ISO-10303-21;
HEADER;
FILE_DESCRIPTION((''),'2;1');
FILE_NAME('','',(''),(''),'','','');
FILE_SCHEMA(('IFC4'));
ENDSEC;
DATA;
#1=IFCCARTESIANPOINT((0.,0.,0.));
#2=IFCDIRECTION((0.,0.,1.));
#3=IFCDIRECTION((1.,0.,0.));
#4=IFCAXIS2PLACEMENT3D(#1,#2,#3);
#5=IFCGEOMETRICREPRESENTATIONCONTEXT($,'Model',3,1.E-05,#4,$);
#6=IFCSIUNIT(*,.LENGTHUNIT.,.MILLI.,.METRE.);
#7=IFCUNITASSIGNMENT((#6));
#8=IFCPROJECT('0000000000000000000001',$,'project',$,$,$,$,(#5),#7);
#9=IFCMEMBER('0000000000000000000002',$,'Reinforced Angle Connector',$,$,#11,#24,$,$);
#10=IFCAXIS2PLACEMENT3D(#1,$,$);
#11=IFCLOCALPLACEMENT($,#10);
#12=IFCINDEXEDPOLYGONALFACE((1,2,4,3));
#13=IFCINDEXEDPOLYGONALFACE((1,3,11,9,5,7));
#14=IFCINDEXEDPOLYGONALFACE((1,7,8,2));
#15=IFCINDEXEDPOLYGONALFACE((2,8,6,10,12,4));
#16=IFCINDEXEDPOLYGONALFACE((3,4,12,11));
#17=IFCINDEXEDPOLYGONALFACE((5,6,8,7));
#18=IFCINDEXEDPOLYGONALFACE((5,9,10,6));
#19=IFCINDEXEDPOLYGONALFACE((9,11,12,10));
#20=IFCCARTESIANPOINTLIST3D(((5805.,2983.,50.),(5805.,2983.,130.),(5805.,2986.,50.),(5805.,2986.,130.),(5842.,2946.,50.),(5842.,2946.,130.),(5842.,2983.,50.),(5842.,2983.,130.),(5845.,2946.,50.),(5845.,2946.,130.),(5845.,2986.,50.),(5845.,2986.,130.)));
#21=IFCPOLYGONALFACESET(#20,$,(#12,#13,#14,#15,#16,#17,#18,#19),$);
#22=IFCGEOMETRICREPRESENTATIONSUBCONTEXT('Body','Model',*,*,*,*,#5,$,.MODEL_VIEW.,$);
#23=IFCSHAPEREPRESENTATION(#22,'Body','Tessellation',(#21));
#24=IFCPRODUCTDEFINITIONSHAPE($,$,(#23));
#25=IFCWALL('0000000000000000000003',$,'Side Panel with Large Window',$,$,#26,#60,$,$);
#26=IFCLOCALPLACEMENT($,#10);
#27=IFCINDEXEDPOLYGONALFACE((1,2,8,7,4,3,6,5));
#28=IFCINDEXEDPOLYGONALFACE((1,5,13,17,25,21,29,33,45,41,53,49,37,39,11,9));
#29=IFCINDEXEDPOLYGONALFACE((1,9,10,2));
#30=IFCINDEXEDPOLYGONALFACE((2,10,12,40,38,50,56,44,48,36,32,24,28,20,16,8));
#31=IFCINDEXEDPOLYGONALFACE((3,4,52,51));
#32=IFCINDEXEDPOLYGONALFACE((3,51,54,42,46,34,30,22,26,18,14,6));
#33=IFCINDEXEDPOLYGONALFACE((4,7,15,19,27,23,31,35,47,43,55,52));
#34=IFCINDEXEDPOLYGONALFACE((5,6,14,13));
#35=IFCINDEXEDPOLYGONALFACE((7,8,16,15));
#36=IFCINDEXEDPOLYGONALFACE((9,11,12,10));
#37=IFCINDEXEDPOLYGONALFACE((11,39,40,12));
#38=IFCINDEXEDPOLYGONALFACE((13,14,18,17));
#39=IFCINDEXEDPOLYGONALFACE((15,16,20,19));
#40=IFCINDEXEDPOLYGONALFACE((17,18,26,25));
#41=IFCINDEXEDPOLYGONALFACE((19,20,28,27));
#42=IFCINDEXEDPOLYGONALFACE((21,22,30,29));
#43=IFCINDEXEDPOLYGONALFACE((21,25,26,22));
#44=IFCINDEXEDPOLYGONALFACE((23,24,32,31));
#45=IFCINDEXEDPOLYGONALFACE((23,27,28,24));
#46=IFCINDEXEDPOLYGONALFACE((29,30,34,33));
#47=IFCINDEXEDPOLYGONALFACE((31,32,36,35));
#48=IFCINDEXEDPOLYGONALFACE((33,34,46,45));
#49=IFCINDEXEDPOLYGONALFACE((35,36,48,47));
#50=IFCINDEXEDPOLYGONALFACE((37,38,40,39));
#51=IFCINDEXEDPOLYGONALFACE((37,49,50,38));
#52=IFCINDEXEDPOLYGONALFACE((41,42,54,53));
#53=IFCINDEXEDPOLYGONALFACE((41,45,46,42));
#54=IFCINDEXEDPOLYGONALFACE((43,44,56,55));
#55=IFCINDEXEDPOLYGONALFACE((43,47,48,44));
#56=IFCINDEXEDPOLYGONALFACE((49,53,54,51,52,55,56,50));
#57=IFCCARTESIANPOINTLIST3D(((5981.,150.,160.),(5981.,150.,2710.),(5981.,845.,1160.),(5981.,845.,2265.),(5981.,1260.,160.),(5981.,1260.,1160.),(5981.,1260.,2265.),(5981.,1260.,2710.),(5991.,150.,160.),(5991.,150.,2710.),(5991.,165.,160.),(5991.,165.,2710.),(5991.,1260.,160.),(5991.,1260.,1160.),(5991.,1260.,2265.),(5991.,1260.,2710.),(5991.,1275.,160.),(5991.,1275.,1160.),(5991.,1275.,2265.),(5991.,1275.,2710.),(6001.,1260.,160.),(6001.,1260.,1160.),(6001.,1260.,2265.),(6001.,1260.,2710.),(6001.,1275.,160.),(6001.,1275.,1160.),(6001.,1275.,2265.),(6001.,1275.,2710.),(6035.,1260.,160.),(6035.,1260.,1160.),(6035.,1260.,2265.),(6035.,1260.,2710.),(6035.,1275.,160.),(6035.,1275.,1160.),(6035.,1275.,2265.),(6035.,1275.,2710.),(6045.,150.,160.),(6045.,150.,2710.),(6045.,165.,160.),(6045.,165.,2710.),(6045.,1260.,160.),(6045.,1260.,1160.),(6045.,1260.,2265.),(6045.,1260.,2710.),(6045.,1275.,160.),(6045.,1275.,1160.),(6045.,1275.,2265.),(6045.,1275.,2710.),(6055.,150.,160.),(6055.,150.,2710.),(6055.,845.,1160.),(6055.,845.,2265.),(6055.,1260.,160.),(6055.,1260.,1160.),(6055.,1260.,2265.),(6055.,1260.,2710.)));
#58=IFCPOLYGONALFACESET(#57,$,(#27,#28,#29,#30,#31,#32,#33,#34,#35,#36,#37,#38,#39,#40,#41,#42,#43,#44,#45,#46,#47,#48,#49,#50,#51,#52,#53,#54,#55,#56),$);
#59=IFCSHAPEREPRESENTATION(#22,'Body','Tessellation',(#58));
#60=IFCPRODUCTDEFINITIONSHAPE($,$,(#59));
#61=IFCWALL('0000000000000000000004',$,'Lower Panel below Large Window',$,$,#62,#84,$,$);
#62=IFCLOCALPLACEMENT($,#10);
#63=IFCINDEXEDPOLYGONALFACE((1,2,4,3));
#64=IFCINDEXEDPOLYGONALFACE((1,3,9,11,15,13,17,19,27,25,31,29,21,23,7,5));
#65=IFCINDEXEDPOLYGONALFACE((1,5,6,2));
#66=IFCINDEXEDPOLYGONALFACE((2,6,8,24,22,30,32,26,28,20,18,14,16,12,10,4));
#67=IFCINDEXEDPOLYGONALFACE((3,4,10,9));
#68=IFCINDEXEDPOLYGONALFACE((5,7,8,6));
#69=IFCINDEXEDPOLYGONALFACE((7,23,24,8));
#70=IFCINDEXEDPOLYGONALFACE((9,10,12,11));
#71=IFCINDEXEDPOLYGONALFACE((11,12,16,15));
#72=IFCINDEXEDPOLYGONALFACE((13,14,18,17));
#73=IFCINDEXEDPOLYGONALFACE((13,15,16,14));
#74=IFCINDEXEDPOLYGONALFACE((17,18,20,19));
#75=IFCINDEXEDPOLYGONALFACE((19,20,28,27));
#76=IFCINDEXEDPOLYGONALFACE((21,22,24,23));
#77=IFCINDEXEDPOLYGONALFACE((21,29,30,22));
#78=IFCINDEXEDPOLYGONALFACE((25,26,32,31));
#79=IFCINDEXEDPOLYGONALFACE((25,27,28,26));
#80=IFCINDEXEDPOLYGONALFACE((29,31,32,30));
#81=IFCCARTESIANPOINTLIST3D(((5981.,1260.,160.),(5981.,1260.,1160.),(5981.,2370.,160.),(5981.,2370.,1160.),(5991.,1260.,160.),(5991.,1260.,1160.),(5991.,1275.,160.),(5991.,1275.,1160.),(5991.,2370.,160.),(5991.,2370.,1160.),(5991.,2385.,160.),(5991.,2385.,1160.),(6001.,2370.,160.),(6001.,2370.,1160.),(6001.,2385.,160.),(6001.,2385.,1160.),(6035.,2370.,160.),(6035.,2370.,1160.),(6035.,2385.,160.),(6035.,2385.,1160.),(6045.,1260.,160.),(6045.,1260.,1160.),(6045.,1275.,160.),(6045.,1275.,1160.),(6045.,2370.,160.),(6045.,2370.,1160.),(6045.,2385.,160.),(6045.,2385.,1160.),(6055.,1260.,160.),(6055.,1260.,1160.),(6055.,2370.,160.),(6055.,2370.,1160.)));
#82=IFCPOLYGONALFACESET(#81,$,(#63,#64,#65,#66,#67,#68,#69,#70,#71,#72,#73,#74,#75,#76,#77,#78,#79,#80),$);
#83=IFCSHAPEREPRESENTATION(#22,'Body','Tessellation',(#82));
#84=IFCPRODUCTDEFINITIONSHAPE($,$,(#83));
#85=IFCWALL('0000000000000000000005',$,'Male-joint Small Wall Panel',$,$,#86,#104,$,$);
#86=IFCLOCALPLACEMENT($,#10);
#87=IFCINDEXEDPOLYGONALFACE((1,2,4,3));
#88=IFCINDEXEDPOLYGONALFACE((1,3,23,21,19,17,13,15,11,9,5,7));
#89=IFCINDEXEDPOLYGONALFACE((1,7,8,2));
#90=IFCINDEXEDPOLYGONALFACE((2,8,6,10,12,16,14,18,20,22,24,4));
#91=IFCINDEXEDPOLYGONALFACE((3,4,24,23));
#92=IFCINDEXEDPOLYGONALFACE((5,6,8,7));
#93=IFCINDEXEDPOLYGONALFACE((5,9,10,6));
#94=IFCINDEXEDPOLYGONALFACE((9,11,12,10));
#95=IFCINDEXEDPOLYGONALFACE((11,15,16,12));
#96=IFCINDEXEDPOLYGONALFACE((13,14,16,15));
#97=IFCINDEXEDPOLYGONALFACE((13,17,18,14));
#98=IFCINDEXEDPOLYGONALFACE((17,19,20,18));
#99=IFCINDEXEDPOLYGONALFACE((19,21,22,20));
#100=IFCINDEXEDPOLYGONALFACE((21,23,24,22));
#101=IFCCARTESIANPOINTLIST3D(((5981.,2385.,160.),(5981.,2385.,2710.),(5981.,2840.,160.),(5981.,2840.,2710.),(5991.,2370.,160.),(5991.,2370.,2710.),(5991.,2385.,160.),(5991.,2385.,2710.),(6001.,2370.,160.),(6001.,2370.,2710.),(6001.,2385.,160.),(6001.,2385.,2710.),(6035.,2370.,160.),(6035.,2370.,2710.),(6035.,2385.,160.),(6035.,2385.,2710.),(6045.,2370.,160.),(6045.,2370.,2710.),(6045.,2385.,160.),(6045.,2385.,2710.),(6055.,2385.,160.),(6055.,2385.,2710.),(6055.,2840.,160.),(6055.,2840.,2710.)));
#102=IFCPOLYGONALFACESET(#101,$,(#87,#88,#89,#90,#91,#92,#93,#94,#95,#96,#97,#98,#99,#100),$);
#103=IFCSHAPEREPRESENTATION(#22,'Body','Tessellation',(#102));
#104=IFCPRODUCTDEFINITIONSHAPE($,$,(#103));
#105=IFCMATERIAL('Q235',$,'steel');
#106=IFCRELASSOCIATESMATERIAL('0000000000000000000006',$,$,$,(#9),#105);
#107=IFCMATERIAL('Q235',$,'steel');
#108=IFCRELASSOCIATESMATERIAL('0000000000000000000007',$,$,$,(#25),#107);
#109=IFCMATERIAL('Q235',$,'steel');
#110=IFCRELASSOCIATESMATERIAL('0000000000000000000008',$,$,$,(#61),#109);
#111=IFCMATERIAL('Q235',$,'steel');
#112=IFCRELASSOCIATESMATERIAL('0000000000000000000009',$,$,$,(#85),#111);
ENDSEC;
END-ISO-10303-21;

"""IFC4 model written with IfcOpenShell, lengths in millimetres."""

from ifc_helpers import new_model, si_unit, frame, origin_with_axes, place, context, subcontext, project, line, indexed_curve, outline, extrude, material, element, save


model = new_model("IFC4")

# Units and contexts
model_context = context("Model", 3, precision=1e-05, world=origin_with_axes())
body_context = subcontext(model_context, "Body", "Model", "MODEL_VIEW")
ifc_project = project(units=[si_unit("LENGTHUNIT", "METRE", prefix="MILLI")], contexts=[model_context])

# Member
ifc_material_1 = material(Name="Q235", Category="steel")
member_1_placement = place(None, frame((5845.0, 2986.0, 50.0), z_axis=(0.0, 0.0, 1.0), x_axis=(-1.0, 0.0, 0.0)))
element("IfcMember", 1, at=member_1_placement, material=ifc_material_1, Name="Reinforced Angle Connector", context=body_context, shape_type="SweptSolid", body=[
    extrude(outline(indexed_curve([(0.0, 0.0), (0.0, 40.0), (3.0, 40.0), (3.0, 3.0), (40.0, 3.0), (40.0, 0.0), (0.0, 0.0)], segments=[line(1, 2, 3, 4, 5, 6, 7, 1)])), origin_with_axes(), (0.0, 0.0, 1.0), 80.0),
])

# Wall, opening
ifc_material_2 = material(Name="Q235", Category="steel")
wall_1_placement = place(None, frame((6055.0, 150.0, 160.0), z_axis=(0.0, 0.0, 1.0), x_axis=(0.0, 1.0, 0.0)))
wall_1 = element("IfcWall", 2, at=wall_1_placement, material=ifc_material_2, Name="Side Panel with Large Window", context=body_context, shape_type="SweptSolid", body=[
    extrude(outline(indexed_curve([(0.0, 0.0), (0.0, 10.0), (15.0, 10.0), (15.0, 64.0), (0.0, 64.0), (0.0, 74.0), (1110.0, 74.0), (1110.0, 64.0), (1125.0, 64.0), (1125.0, 54.0), (1125.0, 54.0), (1110.0, 54.0), (1110.0, 20.0), (1125.0, 20.0), (1125.0, 10.0), (1110.0, 10.0), (1110.0, 0.0), (0.0, 0.0)], segments=[line(1, 2, 3, 4, 5, 6, 7, 8, 9, 10, 11, 12, 13, 14, 15, 16, 17, 18, 1)])), origin_with_axes(), (0.0, 0.0, 1.0), 2550.0),
])
opening_1_placement = place(wall_1_placement, frame((695.0, 0.0, 1000.0), z_axis=(0.0, 0.0, 1.0), x_axis=(1.0, 0.0, 0.0)))
element("IfcOpeningElement", 3, at=opening_1_placement, cuts=wall_1, context=body_context, shape_type="SweptSolid", body=[
    extrude(outline(indexed_curve([(0.0, 0.0), (0.0, 74.0), (430.0, 74.0), (430.0, 0.0)], segments=[line(1, 2, 3, 4, 1)])), origin_with_axes(), (0.0, 0.0, 1.0), 1105.0),
])

# Walls
ifc_material_3 = material(Name="Q235", Category="steel")
wall_2_placement = place(None, frame((6055.0, 1260.0, 160.0), z_axis=(0.0, 0.0, 1.0), x_axis=(0.0, 1.0, 0.0)))
element("IfcWall", 4, at=wall_2_placement, material=ifc_material_3, Name="Lower Panel below Large Window", context=body_context, shape_type="SweptSolid", body=[
    extrude(outline(indexed_curve([(0.0, 0.0), (0.0, 10.0), (15.0, 10.0), (15.0, 64.0), (0.0, 64.0), (0.0, 74.0), (1110.0, 74.0), (1110.0, 64.0), (1125.0, 64.0), (1125.0, 54.0), (1125.0, 54.0), (1110.0, 54.0), (1110.0, 20.0), (1125.0, 20.0), (1125.0, 10.0), (1110.0, 10.0), (1110.0, 0.0), (0.0, 0.0)], segments=[line(1, 2, 3, 4, 5, 6, 7, 8, 9, 10, 11, 12, 13, 14, 15, 16, 17, 18, 1)])), origin_with_axes(), (0.0, 0.0, 1.0), 1000.0),
])
ifc_material_4 = material(Name="Q235", Category="steel")
wall_3_placement = place(None, frame((5981.0, 2840.0, 160.0), z_axis=(0.0, 0.0, 1.0), x_axis=(0.0, -1.0, 0.0)))
element("IfcWall", 5, at=wall_3_placement, material=ifc_material_4, Name="Male-joint Small Wall Panel", context=body_context, shape_type="SweptSolid", body=[
    extrude(outline(indexed_curve([(0.0, 0.0), (0.0, 74.0), (455.0, 74.0), (455.0, 64.0), (470.0, 64.0), (470.0, 54.0), (455.0, 54.0), (455.0, 20.0), (470.0, 20.0), (470.0, 10.0), (455.0, 10.0), (455.0, 0.0), (0.0, 0.0)], segments=[line(1, 2, 3, 4, 5, 6, 7, 8, 9, 10, 11, 12, 13, 1)])), origin_with_axes(), (0.0, 0.0, 1.0), 2550.0),
])

save(model, "model.ifc")
